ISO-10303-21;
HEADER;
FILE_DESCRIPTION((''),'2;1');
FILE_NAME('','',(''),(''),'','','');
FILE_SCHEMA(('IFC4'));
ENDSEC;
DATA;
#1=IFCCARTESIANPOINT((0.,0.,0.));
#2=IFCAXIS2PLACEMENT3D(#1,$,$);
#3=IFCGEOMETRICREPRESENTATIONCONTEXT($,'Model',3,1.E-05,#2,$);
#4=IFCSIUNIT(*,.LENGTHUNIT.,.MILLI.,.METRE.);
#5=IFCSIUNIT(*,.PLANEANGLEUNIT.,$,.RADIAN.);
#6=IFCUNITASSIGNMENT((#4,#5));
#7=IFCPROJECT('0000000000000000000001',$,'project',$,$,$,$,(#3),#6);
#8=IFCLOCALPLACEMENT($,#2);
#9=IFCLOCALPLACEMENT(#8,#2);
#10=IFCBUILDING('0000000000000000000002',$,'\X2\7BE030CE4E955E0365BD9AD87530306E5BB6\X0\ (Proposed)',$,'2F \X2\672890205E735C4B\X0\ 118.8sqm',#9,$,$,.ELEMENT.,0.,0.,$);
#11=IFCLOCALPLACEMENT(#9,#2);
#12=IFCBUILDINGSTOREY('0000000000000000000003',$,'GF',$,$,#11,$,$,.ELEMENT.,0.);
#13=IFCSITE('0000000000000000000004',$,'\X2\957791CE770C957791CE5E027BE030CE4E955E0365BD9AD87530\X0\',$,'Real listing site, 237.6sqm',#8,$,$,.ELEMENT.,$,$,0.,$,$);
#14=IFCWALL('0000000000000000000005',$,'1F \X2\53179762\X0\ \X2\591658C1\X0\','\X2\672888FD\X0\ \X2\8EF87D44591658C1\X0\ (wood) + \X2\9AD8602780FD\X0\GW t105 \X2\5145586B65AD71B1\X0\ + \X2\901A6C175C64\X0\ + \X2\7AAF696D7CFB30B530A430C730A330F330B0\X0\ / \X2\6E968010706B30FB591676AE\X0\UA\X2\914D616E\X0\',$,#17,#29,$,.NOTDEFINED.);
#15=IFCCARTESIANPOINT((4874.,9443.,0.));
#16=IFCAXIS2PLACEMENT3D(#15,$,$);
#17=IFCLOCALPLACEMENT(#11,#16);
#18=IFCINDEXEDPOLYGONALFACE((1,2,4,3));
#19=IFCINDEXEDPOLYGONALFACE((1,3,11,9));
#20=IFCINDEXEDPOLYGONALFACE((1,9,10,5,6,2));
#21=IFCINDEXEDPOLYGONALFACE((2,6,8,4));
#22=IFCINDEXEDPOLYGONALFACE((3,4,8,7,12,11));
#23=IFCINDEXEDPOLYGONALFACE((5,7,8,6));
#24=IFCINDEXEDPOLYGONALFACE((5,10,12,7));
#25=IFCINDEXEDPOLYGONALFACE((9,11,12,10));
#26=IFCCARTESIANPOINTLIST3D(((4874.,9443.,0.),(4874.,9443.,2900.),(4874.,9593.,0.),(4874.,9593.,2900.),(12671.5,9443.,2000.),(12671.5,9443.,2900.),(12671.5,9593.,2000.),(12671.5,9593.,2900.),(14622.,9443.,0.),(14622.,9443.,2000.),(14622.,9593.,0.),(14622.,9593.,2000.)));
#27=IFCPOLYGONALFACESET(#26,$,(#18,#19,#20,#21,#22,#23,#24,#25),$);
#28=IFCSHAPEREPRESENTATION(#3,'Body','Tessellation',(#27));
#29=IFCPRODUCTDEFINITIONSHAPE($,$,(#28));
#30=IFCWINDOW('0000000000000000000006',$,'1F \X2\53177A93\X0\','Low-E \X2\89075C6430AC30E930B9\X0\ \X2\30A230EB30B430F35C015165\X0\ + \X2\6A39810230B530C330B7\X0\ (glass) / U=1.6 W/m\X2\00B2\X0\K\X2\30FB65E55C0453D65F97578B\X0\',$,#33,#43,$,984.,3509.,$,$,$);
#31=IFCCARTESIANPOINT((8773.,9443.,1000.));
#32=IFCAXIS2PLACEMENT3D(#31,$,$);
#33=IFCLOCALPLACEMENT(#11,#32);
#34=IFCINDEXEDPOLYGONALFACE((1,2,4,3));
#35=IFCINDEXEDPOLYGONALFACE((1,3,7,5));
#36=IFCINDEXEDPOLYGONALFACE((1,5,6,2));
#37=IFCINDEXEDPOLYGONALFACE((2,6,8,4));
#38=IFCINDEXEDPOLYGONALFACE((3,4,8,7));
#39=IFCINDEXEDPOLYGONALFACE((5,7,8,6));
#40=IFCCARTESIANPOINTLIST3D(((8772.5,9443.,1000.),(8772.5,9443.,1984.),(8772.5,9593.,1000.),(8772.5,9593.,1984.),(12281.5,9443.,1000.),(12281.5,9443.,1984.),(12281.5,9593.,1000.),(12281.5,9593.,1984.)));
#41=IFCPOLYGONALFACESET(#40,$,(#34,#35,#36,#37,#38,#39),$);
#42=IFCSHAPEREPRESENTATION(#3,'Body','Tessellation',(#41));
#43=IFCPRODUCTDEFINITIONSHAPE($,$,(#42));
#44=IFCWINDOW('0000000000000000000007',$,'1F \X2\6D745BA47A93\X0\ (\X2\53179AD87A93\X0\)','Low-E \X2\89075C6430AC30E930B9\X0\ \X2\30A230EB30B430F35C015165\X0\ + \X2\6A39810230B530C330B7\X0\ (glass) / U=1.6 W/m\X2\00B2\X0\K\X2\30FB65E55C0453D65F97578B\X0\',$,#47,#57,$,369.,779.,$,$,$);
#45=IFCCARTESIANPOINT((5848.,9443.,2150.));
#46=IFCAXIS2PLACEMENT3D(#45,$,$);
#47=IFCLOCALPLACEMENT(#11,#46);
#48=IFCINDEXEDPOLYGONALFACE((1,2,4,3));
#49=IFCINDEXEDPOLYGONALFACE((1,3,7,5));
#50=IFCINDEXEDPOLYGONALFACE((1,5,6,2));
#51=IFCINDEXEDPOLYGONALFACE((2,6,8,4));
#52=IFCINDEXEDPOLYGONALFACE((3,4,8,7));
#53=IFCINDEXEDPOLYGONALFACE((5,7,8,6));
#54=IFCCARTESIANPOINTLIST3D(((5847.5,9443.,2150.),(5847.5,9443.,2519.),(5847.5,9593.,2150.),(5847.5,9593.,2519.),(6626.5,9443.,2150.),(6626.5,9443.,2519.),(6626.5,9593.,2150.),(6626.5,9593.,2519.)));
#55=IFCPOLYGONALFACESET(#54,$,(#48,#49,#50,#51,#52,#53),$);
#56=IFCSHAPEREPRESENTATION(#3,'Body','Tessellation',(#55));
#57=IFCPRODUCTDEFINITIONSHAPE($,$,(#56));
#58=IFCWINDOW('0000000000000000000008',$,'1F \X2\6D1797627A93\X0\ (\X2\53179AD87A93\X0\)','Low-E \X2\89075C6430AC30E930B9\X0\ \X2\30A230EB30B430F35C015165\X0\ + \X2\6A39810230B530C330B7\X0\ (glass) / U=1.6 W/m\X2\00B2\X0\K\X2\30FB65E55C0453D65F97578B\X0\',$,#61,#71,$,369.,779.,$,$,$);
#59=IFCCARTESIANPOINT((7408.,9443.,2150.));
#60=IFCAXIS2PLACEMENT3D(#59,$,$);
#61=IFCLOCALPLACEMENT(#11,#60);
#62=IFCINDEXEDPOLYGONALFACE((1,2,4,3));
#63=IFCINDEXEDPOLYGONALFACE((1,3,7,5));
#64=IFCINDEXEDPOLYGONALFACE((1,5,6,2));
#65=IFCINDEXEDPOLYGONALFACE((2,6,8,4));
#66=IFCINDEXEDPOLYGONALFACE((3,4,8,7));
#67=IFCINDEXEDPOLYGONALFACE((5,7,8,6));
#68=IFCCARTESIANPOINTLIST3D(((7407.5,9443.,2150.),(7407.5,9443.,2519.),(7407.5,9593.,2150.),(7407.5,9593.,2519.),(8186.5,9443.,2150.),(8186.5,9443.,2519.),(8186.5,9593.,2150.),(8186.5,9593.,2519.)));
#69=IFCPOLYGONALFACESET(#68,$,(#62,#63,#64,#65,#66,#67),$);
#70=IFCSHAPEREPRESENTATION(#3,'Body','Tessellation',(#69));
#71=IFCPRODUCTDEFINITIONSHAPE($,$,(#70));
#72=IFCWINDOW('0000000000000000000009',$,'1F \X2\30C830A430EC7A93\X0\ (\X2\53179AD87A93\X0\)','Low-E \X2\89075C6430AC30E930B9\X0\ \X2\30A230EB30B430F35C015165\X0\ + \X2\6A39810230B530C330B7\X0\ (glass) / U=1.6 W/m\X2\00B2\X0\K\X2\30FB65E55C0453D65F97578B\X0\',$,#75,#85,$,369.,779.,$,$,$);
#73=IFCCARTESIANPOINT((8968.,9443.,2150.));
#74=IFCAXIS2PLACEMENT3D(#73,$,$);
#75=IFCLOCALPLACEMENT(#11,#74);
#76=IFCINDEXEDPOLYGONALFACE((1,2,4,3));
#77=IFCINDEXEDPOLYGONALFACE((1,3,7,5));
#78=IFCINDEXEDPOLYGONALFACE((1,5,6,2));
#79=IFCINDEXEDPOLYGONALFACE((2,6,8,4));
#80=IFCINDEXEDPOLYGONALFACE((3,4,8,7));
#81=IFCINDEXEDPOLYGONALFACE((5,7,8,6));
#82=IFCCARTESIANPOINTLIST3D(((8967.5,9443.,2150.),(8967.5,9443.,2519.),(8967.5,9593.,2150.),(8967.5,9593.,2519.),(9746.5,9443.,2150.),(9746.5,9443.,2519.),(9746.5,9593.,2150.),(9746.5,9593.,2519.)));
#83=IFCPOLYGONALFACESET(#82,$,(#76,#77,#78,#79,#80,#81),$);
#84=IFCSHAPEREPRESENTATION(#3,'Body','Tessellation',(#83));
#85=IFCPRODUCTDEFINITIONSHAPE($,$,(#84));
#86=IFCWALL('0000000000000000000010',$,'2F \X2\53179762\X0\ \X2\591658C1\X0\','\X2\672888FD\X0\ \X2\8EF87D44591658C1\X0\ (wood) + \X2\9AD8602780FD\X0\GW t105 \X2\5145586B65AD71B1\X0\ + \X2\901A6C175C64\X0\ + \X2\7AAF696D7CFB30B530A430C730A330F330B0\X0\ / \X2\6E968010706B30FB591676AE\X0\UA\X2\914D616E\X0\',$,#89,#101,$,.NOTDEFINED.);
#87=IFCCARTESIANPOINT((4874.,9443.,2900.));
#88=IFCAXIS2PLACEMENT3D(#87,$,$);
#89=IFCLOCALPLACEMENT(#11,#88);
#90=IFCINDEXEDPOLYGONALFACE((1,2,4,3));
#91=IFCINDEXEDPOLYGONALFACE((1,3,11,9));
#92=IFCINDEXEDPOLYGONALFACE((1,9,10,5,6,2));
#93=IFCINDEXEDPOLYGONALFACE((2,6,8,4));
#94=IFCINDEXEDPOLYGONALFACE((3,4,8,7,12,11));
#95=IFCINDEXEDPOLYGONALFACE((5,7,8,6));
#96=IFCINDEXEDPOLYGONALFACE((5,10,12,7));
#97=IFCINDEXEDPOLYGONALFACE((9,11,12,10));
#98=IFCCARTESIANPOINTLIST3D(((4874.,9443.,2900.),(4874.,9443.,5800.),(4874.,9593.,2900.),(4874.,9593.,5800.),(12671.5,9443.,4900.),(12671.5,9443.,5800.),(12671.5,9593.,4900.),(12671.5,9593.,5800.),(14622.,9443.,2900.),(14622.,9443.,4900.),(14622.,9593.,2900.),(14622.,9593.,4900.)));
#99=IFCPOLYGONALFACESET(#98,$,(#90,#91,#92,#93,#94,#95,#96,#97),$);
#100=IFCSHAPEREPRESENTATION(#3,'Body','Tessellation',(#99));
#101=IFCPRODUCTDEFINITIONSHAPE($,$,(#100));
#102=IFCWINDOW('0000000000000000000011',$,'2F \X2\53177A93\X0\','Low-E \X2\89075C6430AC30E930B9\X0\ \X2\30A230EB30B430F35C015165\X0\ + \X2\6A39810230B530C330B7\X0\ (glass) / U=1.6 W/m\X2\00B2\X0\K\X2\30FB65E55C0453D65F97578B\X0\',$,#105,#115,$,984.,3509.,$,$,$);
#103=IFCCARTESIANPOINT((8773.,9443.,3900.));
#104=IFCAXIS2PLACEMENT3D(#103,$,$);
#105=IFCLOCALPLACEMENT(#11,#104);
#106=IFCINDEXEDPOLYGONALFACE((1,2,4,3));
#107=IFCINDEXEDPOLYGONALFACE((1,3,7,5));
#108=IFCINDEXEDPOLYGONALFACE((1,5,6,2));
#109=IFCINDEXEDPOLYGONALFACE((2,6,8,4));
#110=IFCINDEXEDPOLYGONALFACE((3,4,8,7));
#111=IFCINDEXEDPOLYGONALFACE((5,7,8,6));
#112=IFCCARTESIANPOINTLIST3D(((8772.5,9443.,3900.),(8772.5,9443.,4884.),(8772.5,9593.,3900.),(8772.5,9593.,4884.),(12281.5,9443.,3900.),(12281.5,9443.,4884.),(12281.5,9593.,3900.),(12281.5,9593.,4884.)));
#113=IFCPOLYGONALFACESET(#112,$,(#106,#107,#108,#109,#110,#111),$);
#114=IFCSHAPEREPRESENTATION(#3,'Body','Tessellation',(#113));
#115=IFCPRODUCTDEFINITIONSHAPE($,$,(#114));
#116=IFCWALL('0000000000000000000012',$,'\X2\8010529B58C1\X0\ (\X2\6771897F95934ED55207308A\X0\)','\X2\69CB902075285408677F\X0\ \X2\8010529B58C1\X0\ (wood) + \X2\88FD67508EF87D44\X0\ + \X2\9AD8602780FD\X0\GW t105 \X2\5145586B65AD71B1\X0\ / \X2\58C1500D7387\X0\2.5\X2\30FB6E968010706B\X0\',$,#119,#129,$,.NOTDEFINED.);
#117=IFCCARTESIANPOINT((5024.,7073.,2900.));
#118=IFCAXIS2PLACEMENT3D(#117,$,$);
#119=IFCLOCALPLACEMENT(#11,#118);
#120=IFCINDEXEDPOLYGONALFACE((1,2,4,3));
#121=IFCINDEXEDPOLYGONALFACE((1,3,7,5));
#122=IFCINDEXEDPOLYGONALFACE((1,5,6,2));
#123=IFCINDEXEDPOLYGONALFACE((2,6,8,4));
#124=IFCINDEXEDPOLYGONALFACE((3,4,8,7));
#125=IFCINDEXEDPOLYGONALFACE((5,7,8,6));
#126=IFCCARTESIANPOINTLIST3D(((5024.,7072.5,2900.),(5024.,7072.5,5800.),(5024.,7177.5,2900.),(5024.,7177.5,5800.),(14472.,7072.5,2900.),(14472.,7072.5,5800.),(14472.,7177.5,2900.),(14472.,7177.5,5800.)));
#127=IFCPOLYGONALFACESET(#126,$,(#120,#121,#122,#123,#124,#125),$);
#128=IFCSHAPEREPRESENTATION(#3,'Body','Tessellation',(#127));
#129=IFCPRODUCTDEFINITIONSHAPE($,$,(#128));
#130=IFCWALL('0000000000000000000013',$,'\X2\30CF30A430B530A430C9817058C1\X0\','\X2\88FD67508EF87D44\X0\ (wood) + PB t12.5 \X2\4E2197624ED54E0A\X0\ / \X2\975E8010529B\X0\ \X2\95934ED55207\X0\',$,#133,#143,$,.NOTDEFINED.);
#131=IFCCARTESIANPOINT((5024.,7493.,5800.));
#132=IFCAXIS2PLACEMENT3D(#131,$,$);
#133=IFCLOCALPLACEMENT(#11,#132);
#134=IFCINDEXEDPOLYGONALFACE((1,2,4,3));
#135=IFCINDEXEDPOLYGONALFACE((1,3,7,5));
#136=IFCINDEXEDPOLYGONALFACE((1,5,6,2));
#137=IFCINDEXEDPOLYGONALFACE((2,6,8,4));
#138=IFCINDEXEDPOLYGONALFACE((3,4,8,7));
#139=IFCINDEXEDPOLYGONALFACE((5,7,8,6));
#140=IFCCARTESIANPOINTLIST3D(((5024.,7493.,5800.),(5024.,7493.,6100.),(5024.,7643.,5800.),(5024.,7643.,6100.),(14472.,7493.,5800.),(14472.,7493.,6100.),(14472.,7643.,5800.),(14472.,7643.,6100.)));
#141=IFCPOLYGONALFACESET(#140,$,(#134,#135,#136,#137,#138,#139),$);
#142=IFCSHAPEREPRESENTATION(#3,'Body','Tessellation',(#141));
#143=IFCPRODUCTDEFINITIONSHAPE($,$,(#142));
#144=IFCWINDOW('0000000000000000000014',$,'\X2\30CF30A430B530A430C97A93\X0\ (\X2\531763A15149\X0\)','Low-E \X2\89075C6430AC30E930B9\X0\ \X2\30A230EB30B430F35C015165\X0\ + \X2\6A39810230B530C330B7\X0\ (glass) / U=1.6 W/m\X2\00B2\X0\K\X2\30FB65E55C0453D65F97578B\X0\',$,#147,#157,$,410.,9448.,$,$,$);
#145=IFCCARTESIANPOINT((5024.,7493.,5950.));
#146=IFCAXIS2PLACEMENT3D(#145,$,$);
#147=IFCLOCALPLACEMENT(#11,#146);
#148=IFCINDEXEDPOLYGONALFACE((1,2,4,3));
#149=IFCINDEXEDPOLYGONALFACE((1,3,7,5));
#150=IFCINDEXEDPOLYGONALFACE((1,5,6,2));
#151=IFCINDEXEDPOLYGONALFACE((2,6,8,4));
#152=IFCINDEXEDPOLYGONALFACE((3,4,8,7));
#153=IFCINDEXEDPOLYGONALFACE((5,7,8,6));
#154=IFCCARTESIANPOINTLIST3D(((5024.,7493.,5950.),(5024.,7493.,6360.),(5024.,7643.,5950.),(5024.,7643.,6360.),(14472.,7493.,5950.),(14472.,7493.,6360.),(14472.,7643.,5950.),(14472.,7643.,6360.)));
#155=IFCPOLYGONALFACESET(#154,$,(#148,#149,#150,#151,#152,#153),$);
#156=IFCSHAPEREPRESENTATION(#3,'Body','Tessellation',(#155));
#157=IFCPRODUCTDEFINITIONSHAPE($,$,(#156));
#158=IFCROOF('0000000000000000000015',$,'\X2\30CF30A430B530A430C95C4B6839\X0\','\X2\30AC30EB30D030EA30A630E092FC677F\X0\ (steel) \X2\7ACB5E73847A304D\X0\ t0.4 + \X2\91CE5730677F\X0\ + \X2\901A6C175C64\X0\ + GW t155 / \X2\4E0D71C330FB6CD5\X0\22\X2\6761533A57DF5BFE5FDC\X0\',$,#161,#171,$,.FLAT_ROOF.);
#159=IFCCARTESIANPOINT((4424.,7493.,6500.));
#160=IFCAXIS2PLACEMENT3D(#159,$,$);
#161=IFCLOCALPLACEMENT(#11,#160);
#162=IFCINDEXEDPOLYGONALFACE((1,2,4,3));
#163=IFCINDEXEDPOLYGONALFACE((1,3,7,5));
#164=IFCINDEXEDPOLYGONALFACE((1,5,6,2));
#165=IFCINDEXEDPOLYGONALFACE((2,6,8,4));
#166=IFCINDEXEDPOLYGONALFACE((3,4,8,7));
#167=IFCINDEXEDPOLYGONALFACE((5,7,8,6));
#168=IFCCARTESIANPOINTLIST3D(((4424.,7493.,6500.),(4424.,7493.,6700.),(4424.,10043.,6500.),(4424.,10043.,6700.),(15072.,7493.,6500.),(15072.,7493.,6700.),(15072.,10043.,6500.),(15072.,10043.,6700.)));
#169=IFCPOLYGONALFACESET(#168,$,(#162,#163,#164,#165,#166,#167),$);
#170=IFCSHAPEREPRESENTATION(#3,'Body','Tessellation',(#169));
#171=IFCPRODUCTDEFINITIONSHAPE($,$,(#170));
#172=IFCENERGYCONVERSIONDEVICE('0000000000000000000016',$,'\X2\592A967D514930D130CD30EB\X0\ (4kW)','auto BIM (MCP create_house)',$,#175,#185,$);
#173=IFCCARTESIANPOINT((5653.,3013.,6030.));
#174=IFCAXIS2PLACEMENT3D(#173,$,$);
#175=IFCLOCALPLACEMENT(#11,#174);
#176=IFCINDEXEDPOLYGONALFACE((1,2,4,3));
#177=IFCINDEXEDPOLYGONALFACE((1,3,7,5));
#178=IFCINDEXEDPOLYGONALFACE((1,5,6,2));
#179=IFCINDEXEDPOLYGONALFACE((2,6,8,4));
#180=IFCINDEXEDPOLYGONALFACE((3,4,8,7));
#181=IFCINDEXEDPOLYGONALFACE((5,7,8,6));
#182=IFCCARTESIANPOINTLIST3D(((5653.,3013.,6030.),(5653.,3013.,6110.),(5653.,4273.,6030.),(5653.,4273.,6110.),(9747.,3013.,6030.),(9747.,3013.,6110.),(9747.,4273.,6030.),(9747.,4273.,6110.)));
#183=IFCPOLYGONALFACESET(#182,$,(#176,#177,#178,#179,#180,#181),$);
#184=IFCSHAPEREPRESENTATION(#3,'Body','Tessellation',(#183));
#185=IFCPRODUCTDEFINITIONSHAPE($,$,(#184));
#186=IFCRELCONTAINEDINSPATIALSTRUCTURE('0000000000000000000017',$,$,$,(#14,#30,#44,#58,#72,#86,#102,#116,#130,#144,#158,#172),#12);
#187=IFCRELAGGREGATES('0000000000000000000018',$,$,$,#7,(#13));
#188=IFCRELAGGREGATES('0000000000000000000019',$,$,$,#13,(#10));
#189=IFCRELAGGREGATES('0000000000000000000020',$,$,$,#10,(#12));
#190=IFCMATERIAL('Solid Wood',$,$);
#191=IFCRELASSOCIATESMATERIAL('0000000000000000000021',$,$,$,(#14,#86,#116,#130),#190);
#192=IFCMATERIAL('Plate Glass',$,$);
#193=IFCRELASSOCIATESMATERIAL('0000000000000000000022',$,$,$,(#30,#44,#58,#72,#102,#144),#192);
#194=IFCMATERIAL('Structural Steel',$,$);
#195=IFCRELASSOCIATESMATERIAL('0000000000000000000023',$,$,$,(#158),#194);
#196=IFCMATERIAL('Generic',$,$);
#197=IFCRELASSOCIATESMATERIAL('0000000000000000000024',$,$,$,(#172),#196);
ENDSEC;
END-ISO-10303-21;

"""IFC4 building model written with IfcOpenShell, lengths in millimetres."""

from ifc_helpers import new_model, si_unit, frame, frame_2d, origin, place, context, project, spatial, rectangle, extrude, material, element, fill, save


model = new_model("IFC4")

# Units and contexts
model_context = context("Model", 3, precision=1e-05, world=origin())
ifc_project = project(units=[si_unit("LENGTHUNIT", "METRE", prefix="MILLI"), si_unit("PLANEANGLEUNIT", "RADIAN")], contexts=[model_context])

# Site, building, storey
site_placement = place(None, origin())
site = spatial("IfcSite", under=ifc_project, at=site_placement, Name="長野県長野市篠ノ井布施高田", ObjectType="Real listing site, 237.6sqm", CompositionType="ELEMENT", RefElevation=0.0)
building_placement = place(site_placement, origin())
building = spatial("IfcBuilding", under=site, at=building_placement, Name="篠ノ井布施高田の家 (Proposed)", ObjectType="2F 木造平屋 118.8sqm", CompositionType="ELEMENT", ElevationOfRefHeight=0.0, ElevationOfTerrain=0.0)
storey_placement = place(building_placement, origin())
storey = spatial("IfcBuildingStorey", under=building, at=storey_placement, Name="GF", CompositionType="ELEMENT", Elevation=0.0)

# Wall, openings, windows
ifc_material_1 = material(Name="Solid Wood")
wall_1_placement = place(storey_placement, frame((4874.0, 9443.0, 0.0)))
wall_1 = element("IfcWall", 1, at=wall_1_placement, inside=storey, material=ifc_material_1, Name="1F 北面 外壁", Description="木製 軸組外壁 (wood) + 高性能GW t105 充填断熱 + 通気層 + 窯業系サイディング / 準耐火・外皮UA配慮", PredefinedType="NOTDEFINED", context=model_context, shape_type="SweptSolid", body=[
    extrude(rectangle(XDim=9748.0, YDim=150.0, at=frame_2d((4874.0, 75.0))), frame((4874.0, 9443.0, 0.0)), (0.0, 0.0, 1.0), 2900.0),
])
opening_1_placement = place(storey_placement, frame((8773.0, 9443.0, 1000.0)))
opening_1 = element("IfcOpeningElement", 2, at=opening_1_placement, cuts=wall_1, PredefinedType="NOTDEFINED", context=model_context, shape_type="SweptSolid", body=[
    extrude(rectangle(XDim=3509.0, YDim=150.0, at=frame_2d((1754.0, 75.0))), frame((8773.0, 9443.0, 1000.0)), (0.0, 0.0, 1.0), 984.0),
])
opening_2_placement = place(storey_placement, frame((5848.0, 9443.0, 2150.0)))
opening_2 = element("IfcOpeningElement", 3, at=opening_2_placement, cuts=wall_1, PredefinedType="NOTDEFINED", context=model_context, shape_type="SweptSolid", body=[
    extrude(rectangle(XDim=779.0, YDim=150.0, at=frame_2d((389.0, 75.0))), frame((5848.0, 9443.0, 2150.0)), (0.0, 0.0, 1.0), 369.0),
])
opening_3_placement = place(storey_placement, frame((7408.0, 9443.0, 2150.0)))
opening_3 = element("IfcOpeningElement", 4, at=opening_3_placement, cuts=wall_1, PredefinedType="NOTDEFINED", context=model_context, shape_type="SweptSolid", body=[
    extrude(rectangle(XDim=779.0, YDim=150.0, at=frame_2d((389.0, 75.0))), frame((7408.0, 9443.0, 2150.0)), (0.0, 0.0, 1.0), 369.0),
])
opening_4_placement = place(storey_placement, frame((8968.0, 9443.0, 2150.0)))
opening_4 = element("IfcOpeningElement", 5, at=opening_4_placement, cuts=wall_1, PredefinedType="NOTDEFINED", context=model_context, shape_type="SweptSolid", body=[
    extrude(rectangle(XDim=779.0, YDim=150.0, at=frame_2d((389.0, 75.0))), frame((8968.0, 9443.0, 2150.0)), (0.0, 0.0, 1.0), 369.0),
])
ifc_material_2 = material(Name="Plate Glass")
window_1_placement = place(storey_placement, frame((8773.0, 9443.0, 1000.0)))
window_1 = element("IfcWindow", 6, at=window_1_placement, inside=storey, material=ifc_material_2, Name="1F 北窓", Description="Low-E 複層ガラス アルゴン封入 + 樹脂サッシ (glass) / U=1.6 W/m²K・日射取得型", OverallHeight=984.0, OverallWidth=3509.0, context=model_context, shape_type="SweptSolid", body=[
    extrude(rectangle(XDim=3509.0, YDim=150.0, at=frame_2d((1754.0, 75.0))), frame((8773.0, 9443.0, 1000.0)), (0.0, 0.0, 1.0), 984.0),
])
fill(opening_1, window_1)
window_2_placement = place(storey_placement, frame((5848.0, 9443.0, 2150.0)))
window_2 = element("IfcWindow", 7, at=window_2_placement, inside=storey, material=ifc_material_2, Name="1F 浴室窓 (北高窓)", Description="Low-E 複層ガラス アルゴン封入 + 樹脂サッシ (glass) / U=1.6 W/m²K・日射取得型", OverallHeight=369.0, OverallWidth=779.0, context=model_context, shape_type="SweptSolid", body=[
    extrude(rectangle(XDim=779.0, YDim=150.0, at=frame_2d((389.0, 75.0))), frame((5848.0, 9443.0, 2150.0)), (0.0, 0.0, 1.0), 369.0),
])
fill(opening_2, window_2)
window_3_placement = place(storey_placement, frame((7408.0, 9443.0, 2150.0)))
window_3 = element("IfcWindow", 8, at=window_3_placement, inside=storey, material=ifc_material_2, Name="1F 洗面窓 (北高窓)", Description="Low-E 複層ガラス アルゴン封入 + 樹脂サッシ (glass) / U=1.6 W/m²K・日射取得型", OverallHeight=369.0, OverallWidth=779.0, context=model_context, shape_type="SweptSolid", body=[
    extrude(rectangle(XDim=779.0, YDim=150.0, at=frame_2d((389.0, 75.0))), frame((7408.0, 9443.0, 2150.0)), (0.0, 0.0, 1.0), 369.0),
])
fill(opening_3, window_3)
window_4_placement = place(storey_placement, frame((8968.0, 9443.0, 2150.0)))
window_4 = element("IfcWindow", 9, at=window_4_placement, inside=storey, material=ifc_material_2, Name="1F トイレ窓 (北高窓)", Description="Low-E 複層ガラス アルゴン封入 + 樹脂サッシ (glass) / U=1.6 W/m²K・日射取得型", OverallHeight=369.0, OverallWidth=779.0, context=model_context, shape_type="SweptSolid", body=[
    extrude(rectangle(XDim=779.0, YDim=150.0, at=frame_2d((389.0, 75.0))), frame((8968.0, 9443.0, 2150.0)), (0.0, 0.0, 1.0), 369.0),
])
fill(opening_4, window_4)

# Wall, opening, window
wall_2_placement = place(storey_placement, frame((4874.0, 9443.0, 2900.0)))
wall_2 = element("IfcWall", 10, at=wall_2_placement, inside=storey, material=ifc_material_1, Name="2F 北面 外壁", Description="木製 軸組外壁 (wood) + 高性能GW t105 充填断熱 + 通気層 + 窯業系サイディング / 準耐火・外皮UA配慮", PredefinedType="NOTDEFINED", context=model_context, shape_type="SweptSolid", body=[
    extrude(rectangle(XDim=9748.0, YDim=150.0, at=frame_2d((4874.0, 75.0))), frame((4874.0, 9443.0, 2900.0)), (0.0, 0.0, 1.0), 2900.0),
])
opening_5_placement = place(storey_placement, frame((8773.0, 9443.0, 3900.0)))
opening_5 = element("IfcOpeningElement", 11, at=opening_5_placement, cuts=wall_2, PredefinedType="NOTDEFINED", context=model_context, shape_type="SweptSolid", body=[
    extrude(rectangle(XDim=3509.0, YDim=150.0, at=frame_2d((1754.0, 75.0))), frame((8773.0, 9443.0, 3900.0)), (0.0, 0.0, 1.0), 984.0),
])
window_5_placement = place(storey_placement, frame((8773.0, 9443.0, 3900.0)))
window_5 = element("IfcWindow", 12, at=window_5_placement, inside=storey, material=ifc_material_2, Name="2F 北窓", Description="Low-E 複層ガラス アルゴン封入 + 樹脂サッシ (glass) / U=1.6 W/m²K・日射取得型", OverallHeight=984.0, OverallWidth=3509.0, context=model_context, shape_type="SweptSolid", body=[
    extrude(rectangle(XDim=3509.0, YDim=150.0, at=frame_2d((1754.0, 75.0))), frame((8773.0, 9443.0, 3900.0)), (0.0, 0.0, 1.0), 984.0),
])
fill(opening_5, window_5)

# Wall
wall_3_placement = place(storey_placement, frame((5024.0, 7073.0, 2900.0)))
element("IfcWall", 13, at=wall_3_placement, inside=storey, material=ifc_material_1, Name="耐力壁 (東西間仕切り)", Description="構造用合板 耐力壁 (wood) + 製材軸組 + 高性能GW t105 充填断熱 / 壁倍率2.5・準耐火", PredefinedType="NOTDEFINED", context=model_context, shape_type="SweptSolid", body=[
    extrude(rectangle(XDim=9448.0, YDim=105.0, at=frame_2d((4724.0, 52.0))), frame((5024.0, 7073.0, 2900.0)), (0.0, 0.0, 1.0), 2900.0),
])

# Wall, opening, window
wall_4_placement = place(storey_placement, frame((5024.0, 7493.0, 5800.0)))
wall_4 = element("IfcWall", 14, at=wall_4_placement, inside=storey, material=ifc_material_1, Name="ハイサイド腰壁", Description="製材軸組 (wood) + PB t12.5 両面仕上 / 非耐力 間仕切", PredefinedType="NOTDEFINED", context=model_context, shape_type="SweptSolid", body=[
    extrude(rectangle(XDim=9448.0, YDim=150.0, at=frame_2d((4724.0, 75.0))), frame((5024.0, 7493.0, 5800.0)), (0.0, 0.0, 1.0), 700.0),
])
opening_6_placement = place(storey_placement, frame((5024.0, 7493.0, 5950.0)))
opening_6 = element("IfcOpeningElement", 15, at=opening_6_placement, cuts=wall_4, PredefinedType="NOTDEFINED", context=model_context, shape_type="SweptSolid", body=[
    extrude(rectangle(XDim=9448.0, YDim=150.0, at=frame_2d((4724.0, 75.0))), frame((5024.0, 7493.0, 5950.0)), (0.0, 0.0, 1.0), 410.0),
])
window_6_placement = place(storey_placement, frame((5024.0, 7493.0, 5950.0)))
window_6 = element("IfcWindow", 16, at=window_6_placement, inside=storey, material=ifc_material_2, Name="ハイサイド窓 (北採光)", Description="Low-E 複層ガラス アルゴン封入 + 樹脂サッシ (glass) / U=1.6 W/m²K・日射取得型", OverallHeight=410.0, OverallWidth=9448.0, context=model_context, shape_type="SweptSolid", body=[
    extrude(rectangle(XDim=9448.0, YDim=150.0, at=frame_2d((4724.0, 75.0))), frame((5024.0, 7493.0, 5950.0)), (0.0, 0.0, 1.0), 410.0),
])
fill(opening_6, window_6)

# Roof
ifc_material_3 = material(Name="Structural Steel")
roof_placement = place(storey_placement, frame((4424.0, 7493.0, 6500.0)))
element("IfcRoof", 17, at=roof_placement, inside=storey, material=ifc_material_3, Name="ハイサイド屋根", Description="ガルバリウム鋼板 (steel) 立平葺き t0.4 + 野地板 + 通気層 + GW t155 / 不燃・法22条区域対応", PredefinedType="FLAT_ROOF", context=model_context, shape_type="SweptSolid", body=[
    extrude(rectangle(XDim=10648.0, YDim=2550.0, at=frame_2d((5324.0, 1275.0))), frame((4424.0, 7493.0, 6500.0)), (0.0, 0.0, 1.0), 200.0),
])

# Energy conversion device
ifc_material_4 = material(Name="Generic")
energy_conversion_device_placement = place(storey_placement, frame((5653.0, 3013.0, 6030.0)))
element("IfcEnergyConversionDevice", 18, at=energy_conversion_device_placement, inside=storey, material=ifc_material_4, Name="太陽光パネル (4kW)", Description="auto BIM (MCP create_house)", context=model_context, shape_type="SweptSolid", body=[
    extrude(rectangle(XDim=4094.0, YDim=1260.0, at=frame_2d((2047.0, 630.0))), frame((5653.0, 3013.0, 6030.0)), (0.0, 0.0, 1.0), 80.0),
])

save(model, "model.ifc")
